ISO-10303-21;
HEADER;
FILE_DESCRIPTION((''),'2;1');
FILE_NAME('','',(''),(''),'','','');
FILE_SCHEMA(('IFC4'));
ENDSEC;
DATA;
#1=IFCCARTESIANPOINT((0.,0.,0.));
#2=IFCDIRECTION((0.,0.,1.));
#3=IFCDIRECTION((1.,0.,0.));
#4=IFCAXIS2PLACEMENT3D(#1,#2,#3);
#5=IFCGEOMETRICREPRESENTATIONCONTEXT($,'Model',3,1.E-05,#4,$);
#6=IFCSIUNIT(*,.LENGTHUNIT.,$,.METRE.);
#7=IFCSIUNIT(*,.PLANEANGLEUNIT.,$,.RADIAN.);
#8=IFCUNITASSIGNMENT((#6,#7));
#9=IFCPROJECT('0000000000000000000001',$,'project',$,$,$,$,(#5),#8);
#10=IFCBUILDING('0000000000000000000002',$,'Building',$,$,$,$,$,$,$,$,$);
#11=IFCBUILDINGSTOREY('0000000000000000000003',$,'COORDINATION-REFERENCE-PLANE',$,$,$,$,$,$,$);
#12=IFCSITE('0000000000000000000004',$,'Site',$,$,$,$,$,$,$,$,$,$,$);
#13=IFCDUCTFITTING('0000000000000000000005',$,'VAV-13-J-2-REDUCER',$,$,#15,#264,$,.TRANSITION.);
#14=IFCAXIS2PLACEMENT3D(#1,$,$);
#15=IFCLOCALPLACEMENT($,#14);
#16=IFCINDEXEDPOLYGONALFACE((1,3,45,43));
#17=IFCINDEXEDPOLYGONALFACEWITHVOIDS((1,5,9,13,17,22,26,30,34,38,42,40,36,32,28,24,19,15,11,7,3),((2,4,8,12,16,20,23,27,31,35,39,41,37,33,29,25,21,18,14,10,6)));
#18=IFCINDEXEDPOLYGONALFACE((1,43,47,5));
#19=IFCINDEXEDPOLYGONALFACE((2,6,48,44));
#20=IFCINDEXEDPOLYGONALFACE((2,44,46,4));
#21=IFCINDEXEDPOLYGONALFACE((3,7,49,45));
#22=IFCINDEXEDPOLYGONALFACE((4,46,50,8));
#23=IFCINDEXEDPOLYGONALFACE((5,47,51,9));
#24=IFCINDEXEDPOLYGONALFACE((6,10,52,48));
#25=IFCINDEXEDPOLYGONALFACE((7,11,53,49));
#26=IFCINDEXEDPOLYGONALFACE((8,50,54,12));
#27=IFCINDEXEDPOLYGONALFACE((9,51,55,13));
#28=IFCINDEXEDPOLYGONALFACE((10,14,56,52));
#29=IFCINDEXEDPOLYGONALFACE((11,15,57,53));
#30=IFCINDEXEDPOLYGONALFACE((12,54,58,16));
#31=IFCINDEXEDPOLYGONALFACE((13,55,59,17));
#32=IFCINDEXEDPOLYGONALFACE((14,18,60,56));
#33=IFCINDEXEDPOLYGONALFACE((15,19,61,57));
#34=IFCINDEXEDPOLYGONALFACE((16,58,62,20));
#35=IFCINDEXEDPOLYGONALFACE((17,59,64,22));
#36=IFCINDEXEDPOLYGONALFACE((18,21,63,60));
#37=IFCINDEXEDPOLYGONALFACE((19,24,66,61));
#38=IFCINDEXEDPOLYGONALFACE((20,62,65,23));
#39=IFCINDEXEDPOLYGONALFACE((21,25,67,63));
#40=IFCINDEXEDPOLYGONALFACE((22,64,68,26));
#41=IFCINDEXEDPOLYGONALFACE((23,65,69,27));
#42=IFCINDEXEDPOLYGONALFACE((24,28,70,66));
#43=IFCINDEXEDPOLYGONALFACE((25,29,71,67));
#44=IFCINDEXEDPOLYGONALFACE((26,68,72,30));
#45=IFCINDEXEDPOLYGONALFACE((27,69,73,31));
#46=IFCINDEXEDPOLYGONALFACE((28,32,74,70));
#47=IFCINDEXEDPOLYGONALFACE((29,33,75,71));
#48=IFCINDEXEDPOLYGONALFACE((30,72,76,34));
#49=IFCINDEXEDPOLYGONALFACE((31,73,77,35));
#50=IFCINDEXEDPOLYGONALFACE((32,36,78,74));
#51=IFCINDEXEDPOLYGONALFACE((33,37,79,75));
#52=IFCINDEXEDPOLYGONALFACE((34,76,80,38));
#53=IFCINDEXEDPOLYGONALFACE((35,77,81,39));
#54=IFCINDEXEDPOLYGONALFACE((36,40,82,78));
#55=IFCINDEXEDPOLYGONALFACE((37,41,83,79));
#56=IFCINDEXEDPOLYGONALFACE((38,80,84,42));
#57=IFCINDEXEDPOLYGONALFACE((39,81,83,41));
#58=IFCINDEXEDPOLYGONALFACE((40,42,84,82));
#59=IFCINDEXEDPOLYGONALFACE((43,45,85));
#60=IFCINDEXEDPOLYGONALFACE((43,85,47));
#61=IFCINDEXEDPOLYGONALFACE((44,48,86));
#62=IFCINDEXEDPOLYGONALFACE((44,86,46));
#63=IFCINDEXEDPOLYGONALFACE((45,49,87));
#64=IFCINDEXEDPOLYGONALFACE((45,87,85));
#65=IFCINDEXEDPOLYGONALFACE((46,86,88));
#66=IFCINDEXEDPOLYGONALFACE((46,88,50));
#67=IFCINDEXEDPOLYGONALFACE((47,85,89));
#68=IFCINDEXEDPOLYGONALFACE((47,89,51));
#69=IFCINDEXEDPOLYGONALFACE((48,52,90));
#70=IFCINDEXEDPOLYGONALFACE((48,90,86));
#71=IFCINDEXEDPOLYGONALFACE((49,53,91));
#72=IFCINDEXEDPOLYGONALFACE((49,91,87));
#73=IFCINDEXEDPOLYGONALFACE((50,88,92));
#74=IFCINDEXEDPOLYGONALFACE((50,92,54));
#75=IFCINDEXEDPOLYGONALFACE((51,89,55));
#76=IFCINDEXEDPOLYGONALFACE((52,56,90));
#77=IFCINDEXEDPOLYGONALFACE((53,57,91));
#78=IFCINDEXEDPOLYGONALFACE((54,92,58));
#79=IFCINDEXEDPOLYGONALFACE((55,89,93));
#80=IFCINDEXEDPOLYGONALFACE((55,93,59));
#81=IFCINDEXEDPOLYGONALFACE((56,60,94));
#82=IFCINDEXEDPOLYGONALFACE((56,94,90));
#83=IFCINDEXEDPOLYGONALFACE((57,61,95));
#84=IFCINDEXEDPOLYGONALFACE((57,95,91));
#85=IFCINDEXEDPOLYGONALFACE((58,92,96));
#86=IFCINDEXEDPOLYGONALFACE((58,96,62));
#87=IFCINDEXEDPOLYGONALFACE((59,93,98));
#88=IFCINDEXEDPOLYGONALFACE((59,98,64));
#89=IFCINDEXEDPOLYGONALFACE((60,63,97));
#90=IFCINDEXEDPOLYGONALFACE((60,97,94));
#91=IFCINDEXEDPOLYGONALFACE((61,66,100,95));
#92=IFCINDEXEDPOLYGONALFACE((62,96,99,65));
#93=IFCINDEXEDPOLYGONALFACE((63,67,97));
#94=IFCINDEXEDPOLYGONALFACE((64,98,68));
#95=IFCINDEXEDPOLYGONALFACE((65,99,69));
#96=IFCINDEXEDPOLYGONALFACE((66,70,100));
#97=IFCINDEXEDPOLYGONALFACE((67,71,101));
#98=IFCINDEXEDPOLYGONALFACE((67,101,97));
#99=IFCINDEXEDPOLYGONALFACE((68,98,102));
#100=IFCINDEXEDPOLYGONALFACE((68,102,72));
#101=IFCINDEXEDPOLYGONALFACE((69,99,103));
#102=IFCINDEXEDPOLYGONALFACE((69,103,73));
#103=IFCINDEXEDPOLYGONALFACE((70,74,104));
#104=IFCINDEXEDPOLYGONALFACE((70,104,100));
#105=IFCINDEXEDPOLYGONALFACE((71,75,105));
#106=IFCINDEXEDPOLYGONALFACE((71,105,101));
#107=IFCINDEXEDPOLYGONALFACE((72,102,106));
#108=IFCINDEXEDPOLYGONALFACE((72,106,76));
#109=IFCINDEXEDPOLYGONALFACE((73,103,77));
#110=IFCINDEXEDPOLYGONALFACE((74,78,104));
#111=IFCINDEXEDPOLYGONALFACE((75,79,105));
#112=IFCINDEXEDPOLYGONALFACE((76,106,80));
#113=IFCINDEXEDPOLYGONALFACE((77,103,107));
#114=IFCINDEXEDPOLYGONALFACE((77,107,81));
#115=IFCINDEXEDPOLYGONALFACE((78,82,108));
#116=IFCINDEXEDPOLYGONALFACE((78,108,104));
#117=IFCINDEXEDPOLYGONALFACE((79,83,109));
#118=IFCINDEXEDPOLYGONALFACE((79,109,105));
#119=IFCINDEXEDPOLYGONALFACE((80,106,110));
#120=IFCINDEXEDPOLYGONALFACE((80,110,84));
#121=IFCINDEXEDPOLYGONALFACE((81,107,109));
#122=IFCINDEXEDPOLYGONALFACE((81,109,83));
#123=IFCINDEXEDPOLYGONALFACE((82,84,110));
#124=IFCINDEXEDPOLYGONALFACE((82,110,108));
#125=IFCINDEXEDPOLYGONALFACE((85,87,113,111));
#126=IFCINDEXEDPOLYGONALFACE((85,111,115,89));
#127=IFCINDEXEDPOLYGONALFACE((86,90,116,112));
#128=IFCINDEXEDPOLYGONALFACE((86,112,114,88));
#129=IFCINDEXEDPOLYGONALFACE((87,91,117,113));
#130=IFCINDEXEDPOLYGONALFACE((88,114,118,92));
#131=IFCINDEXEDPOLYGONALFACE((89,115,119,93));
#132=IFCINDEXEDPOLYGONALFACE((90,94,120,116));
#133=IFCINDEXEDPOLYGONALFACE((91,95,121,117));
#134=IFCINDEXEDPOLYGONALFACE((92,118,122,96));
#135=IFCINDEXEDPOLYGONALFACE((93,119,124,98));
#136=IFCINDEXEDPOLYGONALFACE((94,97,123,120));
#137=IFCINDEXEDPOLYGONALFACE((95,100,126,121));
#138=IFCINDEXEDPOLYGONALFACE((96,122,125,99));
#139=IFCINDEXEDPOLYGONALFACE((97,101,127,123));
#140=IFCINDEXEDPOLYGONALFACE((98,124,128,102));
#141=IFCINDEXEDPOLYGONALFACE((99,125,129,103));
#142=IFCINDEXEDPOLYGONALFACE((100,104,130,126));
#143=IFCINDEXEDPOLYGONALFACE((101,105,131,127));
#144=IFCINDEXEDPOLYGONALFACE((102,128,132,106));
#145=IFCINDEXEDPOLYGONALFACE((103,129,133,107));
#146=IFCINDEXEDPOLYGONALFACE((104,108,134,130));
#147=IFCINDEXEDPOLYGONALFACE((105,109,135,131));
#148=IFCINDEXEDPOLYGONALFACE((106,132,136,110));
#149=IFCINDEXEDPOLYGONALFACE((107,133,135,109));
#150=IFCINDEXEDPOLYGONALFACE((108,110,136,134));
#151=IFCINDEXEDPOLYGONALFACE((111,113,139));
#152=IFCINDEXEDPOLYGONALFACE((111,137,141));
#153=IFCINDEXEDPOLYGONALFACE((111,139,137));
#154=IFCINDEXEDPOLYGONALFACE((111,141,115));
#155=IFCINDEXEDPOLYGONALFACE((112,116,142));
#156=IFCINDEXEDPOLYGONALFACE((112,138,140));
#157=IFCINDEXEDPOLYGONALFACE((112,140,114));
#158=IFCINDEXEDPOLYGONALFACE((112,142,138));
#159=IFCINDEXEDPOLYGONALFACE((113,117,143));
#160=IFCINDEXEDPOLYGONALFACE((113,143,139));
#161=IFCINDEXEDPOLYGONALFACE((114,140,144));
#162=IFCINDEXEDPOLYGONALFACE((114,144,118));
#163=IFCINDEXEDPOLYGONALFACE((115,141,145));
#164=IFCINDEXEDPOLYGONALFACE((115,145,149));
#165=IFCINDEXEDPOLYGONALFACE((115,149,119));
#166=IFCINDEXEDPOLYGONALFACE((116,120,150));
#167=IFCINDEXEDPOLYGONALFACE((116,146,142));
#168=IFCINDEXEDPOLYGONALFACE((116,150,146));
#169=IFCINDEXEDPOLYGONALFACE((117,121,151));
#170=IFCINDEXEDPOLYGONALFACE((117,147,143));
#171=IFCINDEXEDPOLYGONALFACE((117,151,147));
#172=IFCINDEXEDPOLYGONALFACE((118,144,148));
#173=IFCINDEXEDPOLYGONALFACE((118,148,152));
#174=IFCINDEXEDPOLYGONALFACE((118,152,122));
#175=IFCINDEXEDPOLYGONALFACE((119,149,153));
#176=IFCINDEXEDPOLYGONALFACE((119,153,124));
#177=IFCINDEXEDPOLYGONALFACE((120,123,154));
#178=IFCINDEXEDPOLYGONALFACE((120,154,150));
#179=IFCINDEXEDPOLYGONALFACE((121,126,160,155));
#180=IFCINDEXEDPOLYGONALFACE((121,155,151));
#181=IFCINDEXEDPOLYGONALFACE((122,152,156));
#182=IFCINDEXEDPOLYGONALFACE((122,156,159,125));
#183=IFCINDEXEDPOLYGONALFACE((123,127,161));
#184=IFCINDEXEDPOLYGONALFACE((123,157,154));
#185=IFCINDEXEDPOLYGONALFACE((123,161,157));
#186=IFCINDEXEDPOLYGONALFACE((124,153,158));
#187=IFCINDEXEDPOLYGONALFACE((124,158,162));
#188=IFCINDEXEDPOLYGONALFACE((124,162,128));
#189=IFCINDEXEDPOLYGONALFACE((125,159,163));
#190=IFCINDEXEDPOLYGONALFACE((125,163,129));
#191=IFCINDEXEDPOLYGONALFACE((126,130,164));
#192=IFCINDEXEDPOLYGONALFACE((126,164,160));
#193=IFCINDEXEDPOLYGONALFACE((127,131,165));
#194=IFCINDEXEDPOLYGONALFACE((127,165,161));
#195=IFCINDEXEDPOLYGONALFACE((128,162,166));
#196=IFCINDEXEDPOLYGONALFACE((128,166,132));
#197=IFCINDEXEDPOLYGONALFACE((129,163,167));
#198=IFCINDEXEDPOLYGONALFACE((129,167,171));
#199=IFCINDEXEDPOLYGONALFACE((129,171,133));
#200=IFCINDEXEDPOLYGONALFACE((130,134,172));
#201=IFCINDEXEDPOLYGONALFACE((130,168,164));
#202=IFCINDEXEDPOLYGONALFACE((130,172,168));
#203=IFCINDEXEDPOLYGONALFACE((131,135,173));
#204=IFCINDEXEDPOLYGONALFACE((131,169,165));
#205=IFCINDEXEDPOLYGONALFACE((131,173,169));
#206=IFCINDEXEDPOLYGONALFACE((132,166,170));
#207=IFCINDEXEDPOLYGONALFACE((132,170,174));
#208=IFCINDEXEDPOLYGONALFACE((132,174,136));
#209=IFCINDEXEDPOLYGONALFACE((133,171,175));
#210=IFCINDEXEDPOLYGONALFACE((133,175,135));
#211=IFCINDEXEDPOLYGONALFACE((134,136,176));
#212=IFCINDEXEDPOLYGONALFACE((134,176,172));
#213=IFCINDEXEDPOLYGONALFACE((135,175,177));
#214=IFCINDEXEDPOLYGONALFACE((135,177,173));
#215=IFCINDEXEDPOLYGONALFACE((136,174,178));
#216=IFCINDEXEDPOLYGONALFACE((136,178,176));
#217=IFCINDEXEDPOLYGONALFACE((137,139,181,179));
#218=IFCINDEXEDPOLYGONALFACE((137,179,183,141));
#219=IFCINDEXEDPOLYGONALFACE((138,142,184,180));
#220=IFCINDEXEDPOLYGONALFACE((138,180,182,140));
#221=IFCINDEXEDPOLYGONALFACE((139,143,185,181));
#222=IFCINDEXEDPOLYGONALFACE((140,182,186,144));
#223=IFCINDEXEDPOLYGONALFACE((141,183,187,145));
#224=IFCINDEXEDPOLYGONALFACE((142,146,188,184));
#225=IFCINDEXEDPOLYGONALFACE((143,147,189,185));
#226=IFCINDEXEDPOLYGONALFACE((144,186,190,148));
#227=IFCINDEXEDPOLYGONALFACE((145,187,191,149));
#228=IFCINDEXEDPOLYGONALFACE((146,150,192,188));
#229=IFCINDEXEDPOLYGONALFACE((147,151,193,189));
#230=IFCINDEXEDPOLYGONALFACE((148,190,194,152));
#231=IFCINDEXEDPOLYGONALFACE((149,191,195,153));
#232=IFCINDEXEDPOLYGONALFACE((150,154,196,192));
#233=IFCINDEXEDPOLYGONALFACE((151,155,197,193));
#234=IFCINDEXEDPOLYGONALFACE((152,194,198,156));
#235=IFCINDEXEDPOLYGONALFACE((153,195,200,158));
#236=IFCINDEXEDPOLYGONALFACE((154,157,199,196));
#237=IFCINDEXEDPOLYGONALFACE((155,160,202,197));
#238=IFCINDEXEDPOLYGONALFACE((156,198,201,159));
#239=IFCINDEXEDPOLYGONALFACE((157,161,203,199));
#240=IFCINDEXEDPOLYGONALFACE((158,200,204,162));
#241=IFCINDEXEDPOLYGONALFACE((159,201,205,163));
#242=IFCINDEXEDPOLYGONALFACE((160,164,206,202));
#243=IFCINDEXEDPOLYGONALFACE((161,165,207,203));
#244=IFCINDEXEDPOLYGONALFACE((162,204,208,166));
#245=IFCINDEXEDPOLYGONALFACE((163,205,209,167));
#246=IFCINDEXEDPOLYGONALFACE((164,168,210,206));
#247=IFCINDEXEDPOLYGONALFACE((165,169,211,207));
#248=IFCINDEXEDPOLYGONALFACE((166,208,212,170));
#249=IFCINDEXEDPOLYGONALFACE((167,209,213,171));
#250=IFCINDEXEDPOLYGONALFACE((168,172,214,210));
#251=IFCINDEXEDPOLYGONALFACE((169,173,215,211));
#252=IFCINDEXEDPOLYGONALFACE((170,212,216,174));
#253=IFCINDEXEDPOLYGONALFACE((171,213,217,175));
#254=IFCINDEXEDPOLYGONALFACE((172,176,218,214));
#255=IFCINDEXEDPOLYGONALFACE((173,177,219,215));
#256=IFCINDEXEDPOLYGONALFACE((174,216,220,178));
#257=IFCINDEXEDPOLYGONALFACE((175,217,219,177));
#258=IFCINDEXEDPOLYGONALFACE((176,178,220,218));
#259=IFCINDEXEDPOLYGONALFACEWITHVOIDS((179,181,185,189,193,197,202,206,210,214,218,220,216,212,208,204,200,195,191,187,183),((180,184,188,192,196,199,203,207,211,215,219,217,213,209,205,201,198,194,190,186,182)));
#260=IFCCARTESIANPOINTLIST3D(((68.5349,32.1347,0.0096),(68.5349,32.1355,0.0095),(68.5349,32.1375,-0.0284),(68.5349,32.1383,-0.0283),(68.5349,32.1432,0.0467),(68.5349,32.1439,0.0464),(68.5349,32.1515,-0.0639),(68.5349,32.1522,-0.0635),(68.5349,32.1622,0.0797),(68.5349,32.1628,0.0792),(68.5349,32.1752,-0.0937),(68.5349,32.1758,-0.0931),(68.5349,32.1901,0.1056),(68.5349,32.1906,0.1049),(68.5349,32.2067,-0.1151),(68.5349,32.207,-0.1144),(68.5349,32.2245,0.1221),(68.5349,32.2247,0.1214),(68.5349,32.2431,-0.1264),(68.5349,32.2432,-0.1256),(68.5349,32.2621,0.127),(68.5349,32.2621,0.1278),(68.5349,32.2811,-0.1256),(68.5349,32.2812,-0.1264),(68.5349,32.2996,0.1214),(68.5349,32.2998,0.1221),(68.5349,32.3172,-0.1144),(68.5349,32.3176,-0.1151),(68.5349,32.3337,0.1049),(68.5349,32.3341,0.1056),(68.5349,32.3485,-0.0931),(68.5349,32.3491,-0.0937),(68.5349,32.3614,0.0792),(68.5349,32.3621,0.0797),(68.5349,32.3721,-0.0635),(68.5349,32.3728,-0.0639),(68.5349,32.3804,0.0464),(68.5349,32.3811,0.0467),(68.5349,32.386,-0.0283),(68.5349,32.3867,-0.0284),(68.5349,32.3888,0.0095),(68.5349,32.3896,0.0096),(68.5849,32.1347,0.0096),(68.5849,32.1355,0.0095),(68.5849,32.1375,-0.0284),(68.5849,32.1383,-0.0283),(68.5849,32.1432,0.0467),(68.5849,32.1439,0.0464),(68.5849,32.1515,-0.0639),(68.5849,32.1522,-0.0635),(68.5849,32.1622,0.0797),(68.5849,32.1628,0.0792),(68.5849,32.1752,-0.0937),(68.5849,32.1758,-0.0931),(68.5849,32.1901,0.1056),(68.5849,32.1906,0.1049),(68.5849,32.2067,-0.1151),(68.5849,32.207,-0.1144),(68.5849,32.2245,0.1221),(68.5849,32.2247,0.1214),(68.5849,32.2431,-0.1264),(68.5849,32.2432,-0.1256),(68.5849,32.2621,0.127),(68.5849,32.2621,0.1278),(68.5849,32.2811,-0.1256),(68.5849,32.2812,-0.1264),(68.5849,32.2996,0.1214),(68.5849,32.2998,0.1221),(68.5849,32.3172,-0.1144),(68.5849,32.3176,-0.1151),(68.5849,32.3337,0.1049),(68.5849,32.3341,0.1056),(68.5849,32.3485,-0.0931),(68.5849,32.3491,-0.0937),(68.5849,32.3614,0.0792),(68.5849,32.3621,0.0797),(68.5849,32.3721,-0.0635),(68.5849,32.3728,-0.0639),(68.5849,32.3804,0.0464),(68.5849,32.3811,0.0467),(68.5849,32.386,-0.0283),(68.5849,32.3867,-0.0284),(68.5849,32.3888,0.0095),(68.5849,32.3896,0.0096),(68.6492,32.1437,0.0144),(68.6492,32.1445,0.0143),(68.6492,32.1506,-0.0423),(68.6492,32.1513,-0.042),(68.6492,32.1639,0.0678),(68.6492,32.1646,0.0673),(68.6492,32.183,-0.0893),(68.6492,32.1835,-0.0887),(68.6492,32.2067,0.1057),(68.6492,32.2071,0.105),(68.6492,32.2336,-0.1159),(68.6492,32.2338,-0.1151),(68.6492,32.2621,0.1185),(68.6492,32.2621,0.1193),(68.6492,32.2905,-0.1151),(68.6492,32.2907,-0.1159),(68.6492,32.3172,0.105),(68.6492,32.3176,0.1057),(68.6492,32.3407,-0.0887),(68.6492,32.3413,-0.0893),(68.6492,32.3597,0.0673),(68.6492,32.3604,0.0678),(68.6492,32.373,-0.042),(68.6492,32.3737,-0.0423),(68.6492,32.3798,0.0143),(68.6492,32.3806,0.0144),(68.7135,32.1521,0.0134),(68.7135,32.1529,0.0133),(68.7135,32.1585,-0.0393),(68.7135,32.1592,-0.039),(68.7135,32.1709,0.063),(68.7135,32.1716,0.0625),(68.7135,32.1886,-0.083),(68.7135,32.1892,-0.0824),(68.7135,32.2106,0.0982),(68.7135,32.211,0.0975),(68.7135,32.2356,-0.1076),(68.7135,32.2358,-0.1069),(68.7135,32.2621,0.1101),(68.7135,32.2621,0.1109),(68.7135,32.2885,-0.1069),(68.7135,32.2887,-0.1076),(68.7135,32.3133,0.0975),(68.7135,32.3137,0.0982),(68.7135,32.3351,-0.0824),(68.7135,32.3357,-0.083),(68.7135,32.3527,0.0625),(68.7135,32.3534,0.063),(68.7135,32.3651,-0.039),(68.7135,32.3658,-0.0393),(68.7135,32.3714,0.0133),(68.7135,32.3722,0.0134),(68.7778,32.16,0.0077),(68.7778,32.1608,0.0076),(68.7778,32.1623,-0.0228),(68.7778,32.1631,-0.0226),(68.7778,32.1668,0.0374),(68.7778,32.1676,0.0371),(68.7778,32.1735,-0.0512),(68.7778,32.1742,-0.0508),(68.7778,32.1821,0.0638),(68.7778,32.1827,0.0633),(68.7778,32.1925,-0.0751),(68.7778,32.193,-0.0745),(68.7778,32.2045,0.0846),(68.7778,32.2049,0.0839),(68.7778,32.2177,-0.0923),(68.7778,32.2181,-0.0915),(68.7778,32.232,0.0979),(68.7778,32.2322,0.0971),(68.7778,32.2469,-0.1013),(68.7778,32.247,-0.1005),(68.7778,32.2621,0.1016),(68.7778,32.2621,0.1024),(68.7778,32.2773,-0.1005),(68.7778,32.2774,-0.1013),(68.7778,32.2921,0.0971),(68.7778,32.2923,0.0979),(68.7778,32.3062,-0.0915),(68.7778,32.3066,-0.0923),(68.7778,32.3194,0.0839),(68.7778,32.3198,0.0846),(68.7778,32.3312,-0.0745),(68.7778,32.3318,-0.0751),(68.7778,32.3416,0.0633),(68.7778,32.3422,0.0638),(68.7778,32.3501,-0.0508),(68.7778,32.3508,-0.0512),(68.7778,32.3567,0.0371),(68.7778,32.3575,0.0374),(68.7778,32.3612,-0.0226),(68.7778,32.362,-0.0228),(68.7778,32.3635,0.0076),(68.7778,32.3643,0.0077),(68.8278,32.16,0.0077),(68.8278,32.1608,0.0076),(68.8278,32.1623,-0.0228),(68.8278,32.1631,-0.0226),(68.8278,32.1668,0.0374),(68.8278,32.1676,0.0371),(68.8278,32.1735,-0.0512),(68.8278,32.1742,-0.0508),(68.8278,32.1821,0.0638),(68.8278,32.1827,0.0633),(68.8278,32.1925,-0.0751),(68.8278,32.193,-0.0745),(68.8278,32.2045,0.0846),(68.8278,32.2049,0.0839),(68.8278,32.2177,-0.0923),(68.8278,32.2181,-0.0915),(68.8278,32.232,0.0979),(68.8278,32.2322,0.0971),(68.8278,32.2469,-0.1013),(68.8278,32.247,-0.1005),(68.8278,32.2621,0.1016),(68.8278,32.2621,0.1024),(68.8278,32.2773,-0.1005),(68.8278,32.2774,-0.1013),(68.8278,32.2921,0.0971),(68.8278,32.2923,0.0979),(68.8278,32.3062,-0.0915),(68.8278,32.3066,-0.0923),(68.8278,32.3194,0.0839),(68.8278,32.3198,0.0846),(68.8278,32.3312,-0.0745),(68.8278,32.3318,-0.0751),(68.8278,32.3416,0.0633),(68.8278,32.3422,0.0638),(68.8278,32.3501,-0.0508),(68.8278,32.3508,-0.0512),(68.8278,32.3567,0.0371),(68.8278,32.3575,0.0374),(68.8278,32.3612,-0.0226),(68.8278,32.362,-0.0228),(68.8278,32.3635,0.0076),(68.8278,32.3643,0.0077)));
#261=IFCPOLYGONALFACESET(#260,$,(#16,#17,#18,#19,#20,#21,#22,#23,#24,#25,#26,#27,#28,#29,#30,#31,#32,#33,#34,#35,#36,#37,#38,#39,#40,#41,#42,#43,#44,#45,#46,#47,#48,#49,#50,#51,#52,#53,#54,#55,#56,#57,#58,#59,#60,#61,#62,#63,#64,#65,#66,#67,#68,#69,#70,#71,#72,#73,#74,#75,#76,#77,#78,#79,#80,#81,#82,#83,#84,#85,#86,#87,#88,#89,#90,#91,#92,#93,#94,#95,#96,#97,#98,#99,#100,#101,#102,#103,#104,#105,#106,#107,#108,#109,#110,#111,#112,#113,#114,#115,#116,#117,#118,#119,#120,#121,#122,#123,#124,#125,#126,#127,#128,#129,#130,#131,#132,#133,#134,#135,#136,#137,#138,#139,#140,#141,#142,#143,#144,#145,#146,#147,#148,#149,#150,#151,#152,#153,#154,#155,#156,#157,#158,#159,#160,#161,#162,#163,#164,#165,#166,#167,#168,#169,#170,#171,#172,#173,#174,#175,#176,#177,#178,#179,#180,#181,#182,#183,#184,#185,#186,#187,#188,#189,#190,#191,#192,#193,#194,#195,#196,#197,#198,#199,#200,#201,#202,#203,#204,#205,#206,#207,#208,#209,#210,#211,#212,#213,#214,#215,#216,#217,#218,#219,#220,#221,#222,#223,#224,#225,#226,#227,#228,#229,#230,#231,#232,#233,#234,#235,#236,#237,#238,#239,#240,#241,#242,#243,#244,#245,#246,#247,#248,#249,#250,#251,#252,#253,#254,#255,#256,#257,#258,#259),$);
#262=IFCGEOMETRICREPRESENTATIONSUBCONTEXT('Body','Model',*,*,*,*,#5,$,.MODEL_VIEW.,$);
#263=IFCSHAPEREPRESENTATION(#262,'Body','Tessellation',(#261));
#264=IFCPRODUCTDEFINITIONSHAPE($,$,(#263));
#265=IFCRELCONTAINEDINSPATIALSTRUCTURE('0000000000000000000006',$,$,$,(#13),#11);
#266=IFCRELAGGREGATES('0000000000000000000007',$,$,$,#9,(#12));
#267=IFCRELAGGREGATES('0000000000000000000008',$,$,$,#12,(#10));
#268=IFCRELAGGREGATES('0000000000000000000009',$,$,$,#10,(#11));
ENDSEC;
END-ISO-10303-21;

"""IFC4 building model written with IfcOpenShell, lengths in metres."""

from ifc_helpers import new_model, entity, si_unit, frame, origin_with_axes, place, context, subcontext, project, spatial, element, save


model = new_model("IFC4")

# Units and contexts
model_context = context("Model", 3, precision=1e-05, world=origin_with_axes())
body_context_1 = subcontext(model_context, "Body", "Model", "MODEL_VIEW")
ifc_project = project(units=[si_unit("LENGTHUNIT", "METRE"), si_unit("PLANEANGLEUNIT", "RADIAN")], contexts=[model_context])

# Site, building, storey
site = spatial("IfcSite", under=ifc_project, Name="Site")
building = spatial("IfcBuilding", under=site, Name="Building")
storey = spatial("IfcBuildingStorey", under=building, Name="COORDINATION-REFERENCE-PLANE")

# Duct fitting
for number, where, z_axis, x_axis, name in (
    (1, (68.5349, 32.2621, 0.0), (0.0, 1.0, 0.0), (0.0, 0.0, 1.0), "VAV-13-J-2-REDUCER"),
):
    element("IfcDuctFitting", number, at=place(None, frame(where, z_axis=z_axis, x_axis=x_axis)), inside=storey, Name=name, PredefinedType="TRANSITION", context=body_context_1, shape_type="SweptSolid", body=[
        entity("IfcRevolvedAreaSolid", entity("IfcArbitraryClosedProfileDef", "AREA", None, entity("IfcPolyline", [entity("IfcCartesianPoint", [0.1278, 0.0]), entity("IfcCartesianPoint", [0.1278, 0.05]), entity("IfcCartesianPoint", [0.1024, 0.2429]), entity("IfcCartesianPoint", [0.1024, 0.2929]), entity("IfcCartesianPoint", [0.1016, 0.2929]), entity("IfcCartesianPoint", [0.1016, 0.2429]), entity("IfcCartesianPoint", [0.127, 0.05]), entity("IfcCartesianPoint", [0.127, 0.0]), entity("IfcCartesianPoint", [0.1278, 0.0])])), entity("IfcAxis2Placement3D", entity("IfcCartesianPoint", [0.0, 0.0, 0.0])), entity("IfcAxis1Placement", entity("IfcCartesianPoint", [0.0, 0.0, 0.0]), entity("IfcDirection", [0.0, 1.0, 0.0])), 6.283185),
    ])

save(model, "model.ifc")
